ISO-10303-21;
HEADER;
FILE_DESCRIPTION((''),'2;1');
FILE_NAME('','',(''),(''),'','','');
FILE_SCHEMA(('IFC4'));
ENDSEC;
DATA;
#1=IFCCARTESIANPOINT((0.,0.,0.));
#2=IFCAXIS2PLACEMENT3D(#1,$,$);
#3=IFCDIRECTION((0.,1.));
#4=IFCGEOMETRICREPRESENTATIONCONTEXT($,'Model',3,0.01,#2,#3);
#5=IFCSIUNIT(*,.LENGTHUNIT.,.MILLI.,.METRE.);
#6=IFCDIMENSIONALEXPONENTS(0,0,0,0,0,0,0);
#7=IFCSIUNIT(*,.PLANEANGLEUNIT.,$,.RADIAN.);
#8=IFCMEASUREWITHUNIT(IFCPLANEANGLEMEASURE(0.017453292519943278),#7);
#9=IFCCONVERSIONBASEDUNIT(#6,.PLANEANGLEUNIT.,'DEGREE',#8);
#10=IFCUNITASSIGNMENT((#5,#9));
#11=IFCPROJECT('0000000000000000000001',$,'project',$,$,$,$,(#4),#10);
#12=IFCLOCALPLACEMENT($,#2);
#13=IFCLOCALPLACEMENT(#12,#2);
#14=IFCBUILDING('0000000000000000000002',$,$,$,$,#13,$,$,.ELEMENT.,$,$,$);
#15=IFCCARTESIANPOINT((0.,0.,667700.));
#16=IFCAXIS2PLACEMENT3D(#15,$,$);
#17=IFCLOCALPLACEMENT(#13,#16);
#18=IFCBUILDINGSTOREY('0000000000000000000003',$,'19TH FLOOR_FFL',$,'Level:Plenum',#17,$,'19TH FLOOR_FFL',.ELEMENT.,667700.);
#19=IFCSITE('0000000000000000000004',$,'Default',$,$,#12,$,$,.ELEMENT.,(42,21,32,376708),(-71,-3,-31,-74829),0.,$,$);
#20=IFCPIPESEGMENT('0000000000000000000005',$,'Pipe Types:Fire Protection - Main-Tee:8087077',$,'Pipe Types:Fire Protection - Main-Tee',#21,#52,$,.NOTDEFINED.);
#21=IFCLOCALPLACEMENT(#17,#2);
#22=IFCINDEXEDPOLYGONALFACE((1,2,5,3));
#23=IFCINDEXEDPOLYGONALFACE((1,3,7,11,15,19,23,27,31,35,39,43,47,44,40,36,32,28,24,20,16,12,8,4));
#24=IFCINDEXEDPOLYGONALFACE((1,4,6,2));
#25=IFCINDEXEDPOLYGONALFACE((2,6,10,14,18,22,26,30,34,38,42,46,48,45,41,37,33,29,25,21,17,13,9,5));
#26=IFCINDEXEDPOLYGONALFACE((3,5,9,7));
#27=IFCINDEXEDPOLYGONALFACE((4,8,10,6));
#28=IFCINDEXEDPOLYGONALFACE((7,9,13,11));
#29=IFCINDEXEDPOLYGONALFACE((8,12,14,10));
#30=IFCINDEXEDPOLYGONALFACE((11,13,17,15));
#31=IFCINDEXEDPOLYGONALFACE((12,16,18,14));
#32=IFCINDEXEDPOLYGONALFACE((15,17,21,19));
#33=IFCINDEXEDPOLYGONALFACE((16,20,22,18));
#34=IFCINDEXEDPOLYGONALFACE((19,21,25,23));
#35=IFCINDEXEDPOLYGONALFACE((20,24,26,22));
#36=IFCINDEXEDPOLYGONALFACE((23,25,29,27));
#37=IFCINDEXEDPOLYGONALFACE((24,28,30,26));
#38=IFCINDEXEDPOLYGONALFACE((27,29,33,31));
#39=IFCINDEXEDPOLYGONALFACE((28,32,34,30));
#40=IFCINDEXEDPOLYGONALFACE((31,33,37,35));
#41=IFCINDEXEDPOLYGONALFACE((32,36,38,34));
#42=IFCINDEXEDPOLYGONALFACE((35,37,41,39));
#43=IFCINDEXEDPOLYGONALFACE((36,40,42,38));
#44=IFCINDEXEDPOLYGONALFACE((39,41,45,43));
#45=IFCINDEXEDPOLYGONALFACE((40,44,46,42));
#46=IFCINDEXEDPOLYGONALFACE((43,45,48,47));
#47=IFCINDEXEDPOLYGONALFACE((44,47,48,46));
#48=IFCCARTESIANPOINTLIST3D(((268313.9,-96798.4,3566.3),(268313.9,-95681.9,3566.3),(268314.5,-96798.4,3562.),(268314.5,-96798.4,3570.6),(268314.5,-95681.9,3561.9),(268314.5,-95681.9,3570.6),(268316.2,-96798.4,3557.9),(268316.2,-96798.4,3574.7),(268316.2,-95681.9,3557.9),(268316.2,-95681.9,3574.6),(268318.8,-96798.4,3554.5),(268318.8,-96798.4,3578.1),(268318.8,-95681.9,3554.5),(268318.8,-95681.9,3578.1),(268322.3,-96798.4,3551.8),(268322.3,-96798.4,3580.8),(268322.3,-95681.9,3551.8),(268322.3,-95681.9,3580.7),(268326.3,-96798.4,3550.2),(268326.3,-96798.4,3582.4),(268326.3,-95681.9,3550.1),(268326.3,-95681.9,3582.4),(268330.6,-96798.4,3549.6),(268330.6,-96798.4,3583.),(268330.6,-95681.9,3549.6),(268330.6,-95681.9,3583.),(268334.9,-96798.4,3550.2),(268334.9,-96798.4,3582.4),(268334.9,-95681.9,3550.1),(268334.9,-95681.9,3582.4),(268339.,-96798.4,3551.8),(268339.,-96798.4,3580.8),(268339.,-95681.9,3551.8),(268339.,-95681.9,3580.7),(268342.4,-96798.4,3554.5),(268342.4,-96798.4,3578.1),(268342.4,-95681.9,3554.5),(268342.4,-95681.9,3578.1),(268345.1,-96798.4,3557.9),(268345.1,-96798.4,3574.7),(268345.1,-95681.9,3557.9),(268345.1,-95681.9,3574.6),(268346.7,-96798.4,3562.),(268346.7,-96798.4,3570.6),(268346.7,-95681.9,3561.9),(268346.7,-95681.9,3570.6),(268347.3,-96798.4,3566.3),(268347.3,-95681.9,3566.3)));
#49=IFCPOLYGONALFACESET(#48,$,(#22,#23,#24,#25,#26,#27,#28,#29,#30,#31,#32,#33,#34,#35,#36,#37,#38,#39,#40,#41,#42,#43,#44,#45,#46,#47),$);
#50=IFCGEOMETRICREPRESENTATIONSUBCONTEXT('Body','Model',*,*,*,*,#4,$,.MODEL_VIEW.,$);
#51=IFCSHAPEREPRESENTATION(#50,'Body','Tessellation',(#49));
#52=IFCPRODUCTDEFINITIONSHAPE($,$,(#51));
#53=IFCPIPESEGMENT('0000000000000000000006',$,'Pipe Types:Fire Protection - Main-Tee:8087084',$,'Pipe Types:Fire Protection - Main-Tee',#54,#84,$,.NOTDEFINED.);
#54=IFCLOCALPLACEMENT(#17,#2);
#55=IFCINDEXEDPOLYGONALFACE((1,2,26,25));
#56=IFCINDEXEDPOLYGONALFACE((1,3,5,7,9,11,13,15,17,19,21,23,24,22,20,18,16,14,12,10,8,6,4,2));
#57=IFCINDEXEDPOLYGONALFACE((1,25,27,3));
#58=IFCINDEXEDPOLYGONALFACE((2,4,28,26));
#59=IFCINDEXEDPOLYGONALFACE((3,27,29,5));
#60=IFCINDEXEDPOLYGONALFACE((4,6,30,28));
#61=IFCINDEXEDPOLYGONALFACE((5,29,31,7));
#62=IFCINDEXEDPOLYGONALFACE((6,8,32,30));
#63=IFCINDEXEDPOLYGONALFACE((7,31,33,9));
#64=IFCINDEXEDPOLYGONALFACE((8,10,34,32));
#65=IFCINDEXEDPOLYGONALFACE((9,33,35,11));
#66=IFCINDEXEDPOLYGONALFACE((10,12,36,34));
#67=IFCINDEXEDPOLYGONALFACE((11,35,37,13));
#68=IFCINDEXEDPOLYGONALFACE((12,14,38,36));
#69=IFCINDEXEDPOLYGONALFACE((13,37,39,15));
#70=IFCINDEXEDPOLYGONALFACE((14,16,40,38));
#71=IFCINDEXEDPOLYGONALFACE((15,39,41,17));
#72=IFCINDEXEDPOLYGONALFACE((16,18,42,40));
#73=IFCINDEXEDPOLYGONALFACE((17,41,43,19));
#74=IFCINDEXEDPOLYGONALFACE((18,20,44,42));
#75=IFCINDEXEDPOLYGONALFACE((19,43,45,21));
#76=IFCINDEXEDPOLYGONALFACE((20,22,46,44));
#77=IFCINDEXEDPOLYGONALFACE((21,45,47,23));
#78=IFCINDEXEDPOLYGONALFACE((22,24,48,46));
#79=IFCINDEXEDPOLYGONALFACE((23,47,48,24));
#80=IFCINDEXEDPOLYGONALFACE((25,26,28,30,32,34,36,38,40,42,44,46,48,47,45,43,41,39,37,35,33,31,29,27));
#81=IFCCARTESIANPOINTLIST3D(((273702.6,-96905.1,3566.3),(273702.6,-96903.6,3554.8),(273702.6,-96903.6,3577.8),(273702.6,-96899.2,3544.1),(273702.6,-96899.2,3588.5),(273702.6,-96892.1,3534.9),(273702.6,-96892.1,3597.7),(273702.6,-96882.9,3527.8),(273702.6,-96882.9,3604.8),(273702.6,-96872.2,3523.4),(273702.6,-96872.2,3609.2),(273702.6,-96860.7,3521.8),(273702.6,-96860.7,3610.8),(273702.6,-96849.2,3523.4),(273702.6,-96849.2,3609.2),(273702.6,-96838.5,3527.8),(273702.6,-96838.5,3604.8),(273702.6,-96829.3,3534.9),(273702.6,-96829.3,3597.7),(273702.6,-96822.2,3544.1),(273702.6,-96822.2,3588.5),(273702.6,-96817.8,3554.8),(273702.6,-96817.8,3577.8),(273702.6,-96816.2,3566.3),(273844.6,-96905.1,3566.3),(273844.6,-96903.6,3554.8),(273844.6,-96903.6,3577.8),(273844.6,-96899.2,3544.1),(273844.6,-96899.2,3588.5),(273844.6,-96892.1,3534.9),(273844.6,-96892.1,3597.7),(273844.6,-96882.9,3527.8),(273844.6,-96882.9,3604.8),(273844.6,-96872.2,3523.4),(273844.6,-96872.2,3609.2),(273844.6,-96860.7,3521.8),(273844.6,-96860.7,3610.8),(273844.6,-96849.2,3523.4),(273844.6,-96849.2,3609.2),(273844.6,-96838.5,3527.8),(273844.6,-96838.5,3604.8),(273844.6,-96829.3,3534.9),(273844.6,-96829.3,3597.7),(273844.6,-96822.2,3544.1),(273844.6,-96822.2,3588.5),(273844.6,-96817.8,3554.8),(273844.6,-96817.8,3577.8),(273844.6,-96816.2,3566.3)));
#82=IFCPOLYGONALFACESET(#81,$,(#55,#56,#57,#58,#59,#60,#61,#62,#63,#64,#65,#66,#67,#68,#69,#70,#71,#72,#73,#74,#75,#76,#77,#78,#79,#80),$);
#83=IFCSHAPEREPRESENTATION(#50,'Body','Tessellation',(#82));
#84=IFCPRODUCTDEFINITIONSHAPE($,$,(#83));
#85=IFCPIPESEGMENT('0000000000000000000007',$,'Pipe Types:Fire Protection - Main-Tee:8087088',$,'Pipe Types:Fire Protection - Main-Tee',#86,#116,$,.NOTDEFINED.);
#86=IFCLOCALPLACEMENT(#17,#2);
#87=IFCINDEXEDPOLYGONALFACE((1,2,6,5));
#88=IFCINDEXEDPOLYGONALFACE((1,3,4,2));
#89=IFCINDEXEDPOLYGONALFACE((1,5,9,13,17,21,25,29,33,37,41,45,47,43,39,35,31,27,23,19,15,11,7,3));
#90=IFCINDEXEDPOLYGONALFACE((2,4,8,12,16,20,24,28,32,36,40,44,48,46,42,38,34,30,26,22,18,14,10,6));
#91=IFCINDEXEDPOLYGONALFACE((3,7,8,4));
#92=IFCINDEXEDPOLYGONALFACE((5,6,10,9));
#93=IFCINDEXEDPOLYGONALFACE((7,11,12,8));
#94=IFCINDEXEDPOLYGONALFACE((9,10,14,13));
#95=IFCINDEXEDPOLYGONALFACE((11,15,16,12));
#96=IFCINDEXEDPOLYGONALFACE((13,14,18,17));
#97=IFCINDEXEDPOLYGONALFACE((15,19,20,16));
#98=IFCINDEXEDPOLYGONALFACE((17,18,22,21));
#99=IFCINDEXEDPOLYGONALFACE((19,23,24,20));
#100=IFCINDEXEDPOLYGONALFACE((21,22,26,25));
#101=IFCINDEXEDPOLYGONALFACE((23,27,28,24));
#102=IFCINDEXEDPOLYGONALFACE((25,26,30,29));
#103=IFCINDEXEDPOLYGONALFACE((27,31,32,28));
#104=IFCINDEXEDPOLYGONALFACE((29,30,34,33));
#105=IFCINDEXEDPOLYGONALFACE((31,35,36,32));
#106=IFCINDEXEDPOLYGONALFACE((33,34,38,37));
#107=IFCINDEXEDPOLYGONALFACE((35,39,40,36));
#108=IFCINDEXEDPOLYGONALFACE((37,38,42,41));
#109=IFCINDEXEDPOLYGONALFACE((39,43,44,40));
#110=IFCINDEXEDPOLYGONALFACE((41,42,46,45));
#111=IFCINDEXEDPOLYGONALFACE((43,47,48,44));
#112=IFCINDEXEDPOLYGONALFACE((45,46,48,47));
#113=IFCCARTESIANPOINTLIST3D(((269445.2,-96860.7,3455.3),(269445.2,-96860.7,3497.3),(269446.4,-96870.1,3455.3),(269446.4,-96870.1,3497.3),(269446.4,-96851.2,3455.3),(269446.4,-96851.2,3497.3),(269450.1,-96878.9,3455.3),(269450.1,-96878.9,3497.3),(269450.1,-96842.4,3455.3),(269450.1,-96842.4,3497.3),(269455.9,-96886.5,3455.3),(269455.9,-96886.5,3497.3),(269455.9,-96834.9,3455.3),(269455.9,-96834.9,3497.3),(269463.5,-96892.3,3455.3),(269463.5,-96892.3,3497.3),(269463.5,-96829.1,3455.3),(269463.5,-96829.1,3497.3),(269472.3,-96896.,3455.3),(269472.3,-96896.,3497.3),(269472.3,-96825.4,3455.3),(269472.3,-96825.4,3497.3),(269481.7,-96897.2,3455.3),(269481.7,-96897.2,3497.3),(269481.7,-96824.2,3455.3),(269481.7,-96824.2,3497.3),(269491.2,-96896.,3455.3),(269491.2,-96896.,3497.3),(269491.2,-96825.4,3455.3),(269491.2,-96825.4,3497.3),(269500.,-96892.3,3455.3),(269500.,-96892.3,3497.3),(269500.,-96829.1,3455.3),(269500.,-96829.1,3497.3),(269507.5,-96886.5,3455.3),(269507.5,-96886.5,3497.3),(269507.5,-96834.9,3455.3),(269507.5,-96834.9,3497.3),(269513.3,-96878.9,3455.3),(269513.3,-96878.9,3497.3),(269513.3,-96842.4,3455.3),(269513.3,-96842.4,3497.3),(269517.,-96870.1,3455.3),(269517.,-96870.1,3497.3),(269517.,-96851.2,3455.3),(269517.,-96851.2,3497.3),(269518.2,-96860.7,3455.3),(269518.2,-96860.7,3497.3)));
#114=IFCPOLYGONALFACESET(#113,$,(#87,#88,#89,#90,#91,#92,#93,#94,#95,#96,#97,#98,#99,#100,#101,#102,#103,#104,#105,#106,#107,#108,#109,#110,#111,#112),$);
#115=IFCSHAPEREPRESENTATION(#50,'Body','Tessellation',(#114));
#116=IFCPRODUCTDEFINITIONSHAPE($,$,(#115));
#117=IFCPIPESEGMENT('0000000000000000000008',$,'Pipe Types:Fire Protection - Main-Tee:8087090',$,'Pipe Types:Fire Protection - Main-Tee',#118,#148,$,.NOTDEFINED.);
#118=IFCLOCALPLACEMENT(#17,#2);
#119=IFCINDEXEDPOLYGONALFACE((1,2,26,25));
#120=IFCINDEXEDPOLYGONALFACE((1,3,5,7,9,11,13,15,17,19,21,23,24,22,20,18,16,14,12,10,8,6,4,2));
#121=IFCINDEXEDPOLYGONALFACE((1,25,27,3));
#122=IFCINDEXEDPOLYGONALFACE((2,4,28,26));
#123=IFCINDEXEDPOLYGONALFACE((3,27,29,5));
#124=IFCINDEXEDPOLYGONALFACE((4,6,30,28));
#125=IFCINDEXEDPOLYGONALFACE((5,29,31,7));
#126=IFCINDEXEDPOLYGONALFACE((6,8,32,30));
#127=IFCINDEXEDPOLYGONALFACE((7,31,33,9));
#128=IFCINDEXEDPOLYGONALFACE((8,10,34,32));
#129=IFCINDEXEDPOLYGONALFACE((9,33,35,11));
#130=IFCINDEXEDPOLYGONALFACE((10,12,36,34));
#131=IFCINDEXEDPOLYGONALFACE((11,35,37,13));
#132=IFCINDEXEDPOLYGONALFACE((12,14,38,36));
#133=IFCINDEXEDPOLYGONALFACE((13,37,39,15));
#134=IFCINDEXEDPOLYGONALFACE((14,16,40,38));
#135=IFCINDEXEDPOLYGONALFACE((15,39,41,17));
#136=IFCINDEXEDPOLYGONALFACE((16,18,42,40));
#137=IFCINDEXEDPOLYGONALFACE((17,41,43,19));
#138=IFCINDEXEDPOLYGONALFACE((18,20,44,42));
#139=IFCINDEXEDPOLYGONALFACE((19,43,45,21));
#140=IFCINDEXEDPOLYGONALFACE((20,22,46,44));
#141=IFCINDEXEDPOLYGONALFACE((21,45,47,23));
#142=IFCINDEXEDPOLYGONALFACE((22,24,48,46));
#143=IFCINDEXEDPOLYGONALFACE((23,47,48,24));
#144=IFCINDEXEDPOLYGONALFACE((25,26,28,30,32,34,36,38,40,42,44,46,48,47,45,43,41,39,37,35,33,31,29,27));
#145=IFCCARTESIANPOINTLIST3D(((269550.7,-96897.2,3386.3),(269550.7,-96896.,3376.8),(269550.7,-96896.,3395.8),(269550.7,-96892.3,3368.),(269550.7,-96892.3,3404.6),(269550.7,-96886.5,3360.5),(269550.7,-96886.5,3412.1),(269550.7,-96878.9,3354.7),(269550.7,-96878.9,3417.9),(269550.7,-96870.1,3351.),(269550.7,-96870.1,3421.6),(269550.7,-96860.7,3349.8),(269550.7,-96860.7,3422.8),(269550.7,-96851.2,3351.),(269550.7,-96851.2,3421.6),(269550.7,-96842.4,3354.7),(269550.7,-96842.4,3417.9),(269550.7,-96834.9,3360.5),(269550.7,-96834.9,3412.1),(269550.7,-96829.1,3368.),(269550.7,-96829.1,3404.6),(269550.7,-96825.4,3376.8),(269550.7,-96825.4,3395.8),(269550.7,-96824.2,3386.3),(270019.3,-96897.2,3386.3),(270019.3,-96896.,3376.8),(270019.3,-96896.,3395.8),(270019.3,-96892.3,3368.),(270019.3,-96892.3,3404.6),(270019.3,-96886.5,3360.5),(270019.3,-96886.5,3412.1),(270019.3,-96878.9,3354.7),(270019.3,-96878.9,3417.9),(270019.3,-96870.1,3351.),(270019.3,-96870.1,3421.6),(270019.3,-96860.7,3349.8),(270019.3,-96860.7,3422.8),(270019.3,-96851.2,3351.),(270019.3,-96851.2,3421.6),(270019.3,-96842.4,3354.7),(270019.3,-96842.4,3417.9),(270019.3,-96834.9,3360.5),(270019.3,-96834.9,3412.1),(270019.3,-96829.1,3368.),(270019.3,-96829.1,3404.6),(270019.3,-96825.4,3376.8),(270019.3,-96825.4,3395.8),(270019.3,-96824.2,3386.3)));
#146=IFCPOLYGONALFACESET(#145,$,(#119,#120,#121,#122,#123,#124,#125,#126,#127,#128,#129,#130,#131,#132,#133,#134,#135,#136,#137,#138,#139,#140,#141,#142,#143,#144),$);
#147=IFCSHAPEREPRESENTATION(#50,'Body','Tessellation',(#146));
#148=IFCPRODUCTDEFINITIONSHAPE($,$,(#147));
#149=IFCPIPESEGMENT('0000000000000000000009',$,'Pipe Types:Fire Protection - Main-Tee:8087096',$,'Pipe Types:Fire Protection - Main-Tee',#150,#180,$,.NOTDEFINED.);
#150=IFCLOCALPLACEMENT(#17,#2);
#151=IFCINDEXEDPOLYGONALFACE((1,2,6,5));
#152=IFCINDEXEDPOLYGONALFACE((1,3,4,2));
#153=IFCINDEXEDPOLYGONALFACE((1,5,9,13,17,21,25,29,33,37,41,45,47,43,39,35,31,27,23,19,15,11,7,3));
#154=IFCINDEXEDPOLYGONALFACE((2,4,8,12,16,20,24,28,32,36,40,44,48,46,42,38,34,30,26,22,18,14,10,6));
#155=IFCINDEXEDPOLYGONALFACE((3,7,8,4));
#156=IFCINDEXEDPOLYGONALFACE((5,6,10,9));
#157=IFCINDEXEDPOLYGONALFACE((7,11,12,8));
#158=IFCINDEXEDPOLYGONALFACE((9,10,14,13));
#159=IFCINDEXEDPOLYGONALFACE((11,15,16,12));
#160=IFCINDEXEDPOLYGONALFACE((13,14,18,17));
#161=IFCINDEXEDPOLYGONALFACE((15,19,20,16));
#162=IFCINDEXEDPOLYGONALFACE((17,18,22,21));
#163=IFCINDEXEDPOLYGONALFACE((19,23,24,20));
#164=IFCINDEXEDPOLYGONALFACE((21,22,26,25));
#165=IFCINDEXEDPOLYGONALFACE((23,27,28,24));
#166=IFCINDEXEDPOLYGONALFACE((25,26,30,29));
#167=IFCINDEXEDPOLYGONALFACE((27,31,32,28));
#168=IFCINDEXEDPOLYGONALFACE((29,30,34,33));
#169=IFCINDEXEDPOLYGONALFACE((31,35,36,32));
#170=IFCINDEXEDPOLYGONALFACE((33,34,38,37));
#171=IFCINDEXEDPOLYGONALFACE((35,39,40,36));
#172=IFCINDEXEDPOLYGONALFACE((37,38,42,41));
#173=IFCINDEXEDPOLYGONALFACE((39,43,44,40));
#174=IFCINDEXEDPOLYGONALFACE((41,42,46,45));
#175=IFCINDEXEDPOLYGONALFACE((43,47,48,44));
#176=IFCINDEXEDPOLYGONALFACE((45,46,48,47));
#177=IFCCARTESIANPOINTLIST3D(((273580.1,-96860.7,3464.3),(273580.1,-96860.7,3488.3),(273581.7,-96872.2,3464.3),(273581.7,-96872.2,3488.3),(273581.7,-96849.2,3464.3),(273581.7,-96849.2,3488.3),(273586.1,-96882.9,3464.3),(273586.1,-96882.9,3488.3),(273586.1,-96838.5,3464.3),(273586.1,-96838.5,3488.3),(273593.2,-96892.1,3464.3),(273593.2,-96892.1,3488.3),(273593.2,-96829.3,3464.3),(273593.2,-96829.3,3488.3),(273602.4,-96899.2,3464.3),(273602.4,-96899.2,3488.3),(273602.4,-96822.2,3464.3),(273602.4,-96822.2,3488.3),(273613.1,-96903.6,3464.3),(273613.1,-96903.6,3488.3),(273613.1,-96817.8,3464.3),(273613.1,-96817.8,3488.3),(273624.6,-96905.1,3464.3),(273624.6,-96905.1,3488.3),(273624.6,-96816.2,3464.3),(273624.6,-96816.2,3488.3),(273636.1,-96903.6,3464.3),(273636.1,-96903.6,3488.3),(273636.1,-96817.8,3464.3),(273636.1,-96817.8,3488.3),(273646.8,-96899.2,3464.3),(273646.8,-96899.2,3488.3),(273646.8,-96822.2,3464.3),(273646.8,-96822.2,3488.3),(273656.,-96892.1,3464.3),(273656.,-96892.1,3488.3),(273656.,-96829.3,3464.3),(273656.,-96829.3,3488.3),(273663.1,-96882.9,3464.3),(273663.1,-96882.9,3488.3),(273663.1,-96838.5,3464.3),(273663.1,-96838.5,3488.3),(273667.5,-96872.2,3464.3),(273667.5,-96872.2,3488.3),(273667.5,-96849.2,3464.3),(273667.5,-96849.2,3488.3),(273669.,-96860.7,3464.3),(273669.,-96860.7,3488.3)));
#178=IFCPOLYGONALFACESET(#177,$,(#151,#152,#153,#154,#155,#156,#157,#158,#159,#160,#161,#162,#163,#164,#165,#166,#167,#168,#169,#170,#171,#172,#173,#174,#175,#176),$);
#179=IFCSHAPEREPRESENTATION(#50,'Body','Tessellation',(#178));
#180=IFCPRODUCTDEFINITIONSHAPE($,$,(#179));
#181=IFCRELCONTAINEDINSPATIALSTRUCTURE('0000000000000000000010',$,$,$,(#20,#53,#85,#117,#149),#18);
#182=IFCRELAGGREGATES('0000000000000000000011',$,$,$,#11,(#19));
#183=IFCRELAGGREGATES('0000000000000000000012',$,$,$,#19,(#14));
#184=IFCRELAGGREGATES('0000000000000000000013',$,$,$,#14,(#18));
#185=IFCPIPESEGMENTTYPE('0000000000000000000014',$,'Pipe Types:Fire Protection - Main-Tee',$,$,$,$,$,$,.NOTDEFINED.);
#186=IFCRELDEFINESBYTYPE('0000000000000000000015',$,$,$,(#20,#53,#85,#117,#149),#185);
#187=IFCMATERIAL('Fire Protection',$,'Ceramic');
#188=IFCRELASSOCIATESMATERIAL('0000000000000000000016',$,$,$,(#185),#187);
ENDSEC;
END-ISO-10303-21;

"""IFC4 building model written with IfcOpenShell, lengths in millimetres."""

from ifc_helpers import new_model, entity, si_unit, converted_unit, direction, frame, origin, place, context, subcontext, project, spatial, arc, indexed_curve, outline, extrude, material, type_object, element, save


model = new_model("IFC4")

# Units and contexts
model_context = context("Model", 3, precision=0.01, world=origin(), true_north=direction((0.0, 1.0)))
body_context = subcontext(model_context, "Body", "Model", "MODEL_VIEW")
ifc_project = project(units=[si_unit("LENGTHUNIT", "METRE", prefix="MILLI"), converted_unit("PLANEANGLEUNIT", "DEGREE", entity("IfcPlaneAngleMeasure", 0.017453292519943278), si_unit("PLANEANGLEUNIT", "RADIAN"), dimensions=[0, 0, 0, 0, 0, 0, 0])], contexts=[model_context])

# Site, building, storey
site_placement = place(None, origin())
site = spatial("IfcSite", under=ifc_project, at=site_placement, Name="Default", CompositionType="ELEMENT", RefLatitude=(42, 21, 32, 376708), RefLongitude=(-71, -3, -31, -74829), RefElevation=0.0)
building_placement = place(site_placement, origin())
building = spatial("IfcBuilding", under=site, at=building_placement, CompositionType="ELEMENT")
storey_placement = place(building_placement, frame((0.0, 0.0, 667700.0)))
storey = spatial("IfcBuildingStorey", under=building, at=storey_placement, Name="19TH FLOOR_FFL", ObjectType="Level:Plenum", LongName="19TH FLOOR_FFL", CompositionType="ELEMENT", Elevation=667700.0)

# Pipe segments
ifc_material = material(Name="Fire Protection", Category="Ceramic")
pipe_segment_type = type_object("IfcPipeSegmentType", Name="Pipe Types:Fire Protection - Main-Tee", PredefinedType="NOTDEFINED", material=ifc_material)
pipe_segment_1_placement = place(storey_placement, origin())
element("IfcPipeSegment", 1, at=pipe_segment_1_placement, inside=storey, type_object=pipe_segment_type, Name="Pipe Types:Fire Protection - Main-Tee:8087077", ObjectType="Pipe Types:Fire Protection - Main-Tee", PredefinedType="NOTDEFINED", context=body_context, shape_type="SweptSolid", body=[
    extrude(outline(indexed_curve([(16.7, 0.0), (11.8, 11.8), (0.0, 16.7), (-11.8, 11.8), (-16.7, 0.0), (-11.8, -11.8), (0.0, -16.7), (11.8, -11.8)], segments=[arc(1, 2, 3), arc(3, 4, 5), arc(5, 6, 7), arc(7, 8, 1)], self_intersect=False)), frame((268330.6, -95681.9, 3566.3), z_axis=(0.0, -1.0, 0.000036), x_axis=(1.0, 0.0, 0.0)), (0.0, 0.0, 1.0), 1116.6),
])
pipe_segment_2_placement = place(storey_placement, origin())
element("IfcPipeSegment", 2, at=pipe_segment_2_placement, inside=storey, type_object=pipe_segment_type, Name="Pipe Types:Fire Protection - Main-Tee:8087084", ObjectType="Pipe Types:Fire Protection - Main-Tee", PredefinedType="NOTDEFINED", context=body_context, shape_type="SweptSolid", body=[
    extrude(outline(indexed_curve([(44.4, 0.0), (31.4, 31.4), (0.0, 44.5), (-31.4, 31.4), (-44.4, 0.0), (-31.4, -31.4), (0.0, -44.4), (31.4, -31.4)], segments=[arc(1, 2, 3), arc(3, 4, 5), arc(5, 6, 7), arc(7, 8, 1)], self_intersect=False)), frame((273702.6, -96860.7, 3566.3), z_axis=(1.0, 0.0, 0.0), x_axis=(0.0, 1.0, 0.0)), (0.0, 0.0, 1.0), 142.0),
])
pipe_segment_3_placement = place(storey_placement, origin())
element("IfcPipeSegment", 3, at=pipe_segment_3_placement, inside=storey, type_object=pipe_segment_type, Name="Pipe Types:Fire Protection - Main-Tee:8087088", ObjectType="Pipe Types:Fire Protection - Main-Tee", PredefinedType="NOTDEFINED", context=body_context, shape_type="SweptSolid", body=[
    extrude(outline(indexed_curve([(36.5, 0.0), (25.8, 25.8), (0.0, 36.5), (-25.8, 25.8), (-36.5, 0.0), (-25.8, -25.8), (0.0, -36.5), (25.8, -25.8)], segments=[arc(1, 2, 3), arc(3, 4, 5), arc(5, 6, 7), arc(7, 8, 1)], self_intersect=False)), frame((269481.7, -96860.7, 3455.3)), (0.0, 0.0, 1.0), 42.0),
])
pipe_segment_4_placement = place(storey_placement, origin())
element("IfcPipeSegment", 4, at=pipe_segment_4_placement, inside=storey, type_object=pipe_segment_type, Name="Pipe Types:Fire Protection - Main-Tee:8087090", ObjectType="Pipe Types:Fire Protection - Main-Tee", PredefinedType="NOTDEFINED", context=body_context, shape_type="SweptSolid", body=[
    extrude(outline(indexed_curve([(36.5, 0.0), (25.8, 25.8), (0.0, 36.5), (-25.8, 25.8), (-36.5, 0.0), (-25.8, -25.8), (0.0, -36.5), (25.8, -25.8)], segments=[arc(1, 2, 3), arc(3, 4, 5), arc(5, 6, 7), arc(7, 8, 1)], self_intersect=False)), frame((269550.7, -96860.7, 3386.3), z_axis=(1.0, 0.0, 0.0), x_axis=(0.0, -1.0, 0.0)), (0.0, 0.0, 1.0), 468.6),
])
pipe_segment_5_placement = place(storey_placement, origin())
element("IfcPipeSegment", 5, at=pipe_segment_5_placement, inside=storey, type_object=pipe_segment_type, Name="Pipe Types:Fire Protection - Main-Tee:8087096", ObjectType="Pipe Types:Fire Protection - Main-Tee", PredefinedType="NOTDEFINED", context=body_context, shape_type="SweptSolid", body=[
    extrude(outline(indexed_curve([(44.5, 0.0), (31.4, 31.4), (0.0, 44.4), (-31.4, 31.4), (-44.5, 0.0), (-31.4, -31.4), (0.0, -44.4), (31.4, -31.4)], segments=[arc(1, 2, 3), arc(3, 4, 5), arc(5, 6, 7), arc(7, 8, 1)], self_intersect=False)), frame((273624.6, -96860.7, 3464.3)), (0.0, 0.0, 1.0), 24.0),
])

save(model, "model.ifc")
